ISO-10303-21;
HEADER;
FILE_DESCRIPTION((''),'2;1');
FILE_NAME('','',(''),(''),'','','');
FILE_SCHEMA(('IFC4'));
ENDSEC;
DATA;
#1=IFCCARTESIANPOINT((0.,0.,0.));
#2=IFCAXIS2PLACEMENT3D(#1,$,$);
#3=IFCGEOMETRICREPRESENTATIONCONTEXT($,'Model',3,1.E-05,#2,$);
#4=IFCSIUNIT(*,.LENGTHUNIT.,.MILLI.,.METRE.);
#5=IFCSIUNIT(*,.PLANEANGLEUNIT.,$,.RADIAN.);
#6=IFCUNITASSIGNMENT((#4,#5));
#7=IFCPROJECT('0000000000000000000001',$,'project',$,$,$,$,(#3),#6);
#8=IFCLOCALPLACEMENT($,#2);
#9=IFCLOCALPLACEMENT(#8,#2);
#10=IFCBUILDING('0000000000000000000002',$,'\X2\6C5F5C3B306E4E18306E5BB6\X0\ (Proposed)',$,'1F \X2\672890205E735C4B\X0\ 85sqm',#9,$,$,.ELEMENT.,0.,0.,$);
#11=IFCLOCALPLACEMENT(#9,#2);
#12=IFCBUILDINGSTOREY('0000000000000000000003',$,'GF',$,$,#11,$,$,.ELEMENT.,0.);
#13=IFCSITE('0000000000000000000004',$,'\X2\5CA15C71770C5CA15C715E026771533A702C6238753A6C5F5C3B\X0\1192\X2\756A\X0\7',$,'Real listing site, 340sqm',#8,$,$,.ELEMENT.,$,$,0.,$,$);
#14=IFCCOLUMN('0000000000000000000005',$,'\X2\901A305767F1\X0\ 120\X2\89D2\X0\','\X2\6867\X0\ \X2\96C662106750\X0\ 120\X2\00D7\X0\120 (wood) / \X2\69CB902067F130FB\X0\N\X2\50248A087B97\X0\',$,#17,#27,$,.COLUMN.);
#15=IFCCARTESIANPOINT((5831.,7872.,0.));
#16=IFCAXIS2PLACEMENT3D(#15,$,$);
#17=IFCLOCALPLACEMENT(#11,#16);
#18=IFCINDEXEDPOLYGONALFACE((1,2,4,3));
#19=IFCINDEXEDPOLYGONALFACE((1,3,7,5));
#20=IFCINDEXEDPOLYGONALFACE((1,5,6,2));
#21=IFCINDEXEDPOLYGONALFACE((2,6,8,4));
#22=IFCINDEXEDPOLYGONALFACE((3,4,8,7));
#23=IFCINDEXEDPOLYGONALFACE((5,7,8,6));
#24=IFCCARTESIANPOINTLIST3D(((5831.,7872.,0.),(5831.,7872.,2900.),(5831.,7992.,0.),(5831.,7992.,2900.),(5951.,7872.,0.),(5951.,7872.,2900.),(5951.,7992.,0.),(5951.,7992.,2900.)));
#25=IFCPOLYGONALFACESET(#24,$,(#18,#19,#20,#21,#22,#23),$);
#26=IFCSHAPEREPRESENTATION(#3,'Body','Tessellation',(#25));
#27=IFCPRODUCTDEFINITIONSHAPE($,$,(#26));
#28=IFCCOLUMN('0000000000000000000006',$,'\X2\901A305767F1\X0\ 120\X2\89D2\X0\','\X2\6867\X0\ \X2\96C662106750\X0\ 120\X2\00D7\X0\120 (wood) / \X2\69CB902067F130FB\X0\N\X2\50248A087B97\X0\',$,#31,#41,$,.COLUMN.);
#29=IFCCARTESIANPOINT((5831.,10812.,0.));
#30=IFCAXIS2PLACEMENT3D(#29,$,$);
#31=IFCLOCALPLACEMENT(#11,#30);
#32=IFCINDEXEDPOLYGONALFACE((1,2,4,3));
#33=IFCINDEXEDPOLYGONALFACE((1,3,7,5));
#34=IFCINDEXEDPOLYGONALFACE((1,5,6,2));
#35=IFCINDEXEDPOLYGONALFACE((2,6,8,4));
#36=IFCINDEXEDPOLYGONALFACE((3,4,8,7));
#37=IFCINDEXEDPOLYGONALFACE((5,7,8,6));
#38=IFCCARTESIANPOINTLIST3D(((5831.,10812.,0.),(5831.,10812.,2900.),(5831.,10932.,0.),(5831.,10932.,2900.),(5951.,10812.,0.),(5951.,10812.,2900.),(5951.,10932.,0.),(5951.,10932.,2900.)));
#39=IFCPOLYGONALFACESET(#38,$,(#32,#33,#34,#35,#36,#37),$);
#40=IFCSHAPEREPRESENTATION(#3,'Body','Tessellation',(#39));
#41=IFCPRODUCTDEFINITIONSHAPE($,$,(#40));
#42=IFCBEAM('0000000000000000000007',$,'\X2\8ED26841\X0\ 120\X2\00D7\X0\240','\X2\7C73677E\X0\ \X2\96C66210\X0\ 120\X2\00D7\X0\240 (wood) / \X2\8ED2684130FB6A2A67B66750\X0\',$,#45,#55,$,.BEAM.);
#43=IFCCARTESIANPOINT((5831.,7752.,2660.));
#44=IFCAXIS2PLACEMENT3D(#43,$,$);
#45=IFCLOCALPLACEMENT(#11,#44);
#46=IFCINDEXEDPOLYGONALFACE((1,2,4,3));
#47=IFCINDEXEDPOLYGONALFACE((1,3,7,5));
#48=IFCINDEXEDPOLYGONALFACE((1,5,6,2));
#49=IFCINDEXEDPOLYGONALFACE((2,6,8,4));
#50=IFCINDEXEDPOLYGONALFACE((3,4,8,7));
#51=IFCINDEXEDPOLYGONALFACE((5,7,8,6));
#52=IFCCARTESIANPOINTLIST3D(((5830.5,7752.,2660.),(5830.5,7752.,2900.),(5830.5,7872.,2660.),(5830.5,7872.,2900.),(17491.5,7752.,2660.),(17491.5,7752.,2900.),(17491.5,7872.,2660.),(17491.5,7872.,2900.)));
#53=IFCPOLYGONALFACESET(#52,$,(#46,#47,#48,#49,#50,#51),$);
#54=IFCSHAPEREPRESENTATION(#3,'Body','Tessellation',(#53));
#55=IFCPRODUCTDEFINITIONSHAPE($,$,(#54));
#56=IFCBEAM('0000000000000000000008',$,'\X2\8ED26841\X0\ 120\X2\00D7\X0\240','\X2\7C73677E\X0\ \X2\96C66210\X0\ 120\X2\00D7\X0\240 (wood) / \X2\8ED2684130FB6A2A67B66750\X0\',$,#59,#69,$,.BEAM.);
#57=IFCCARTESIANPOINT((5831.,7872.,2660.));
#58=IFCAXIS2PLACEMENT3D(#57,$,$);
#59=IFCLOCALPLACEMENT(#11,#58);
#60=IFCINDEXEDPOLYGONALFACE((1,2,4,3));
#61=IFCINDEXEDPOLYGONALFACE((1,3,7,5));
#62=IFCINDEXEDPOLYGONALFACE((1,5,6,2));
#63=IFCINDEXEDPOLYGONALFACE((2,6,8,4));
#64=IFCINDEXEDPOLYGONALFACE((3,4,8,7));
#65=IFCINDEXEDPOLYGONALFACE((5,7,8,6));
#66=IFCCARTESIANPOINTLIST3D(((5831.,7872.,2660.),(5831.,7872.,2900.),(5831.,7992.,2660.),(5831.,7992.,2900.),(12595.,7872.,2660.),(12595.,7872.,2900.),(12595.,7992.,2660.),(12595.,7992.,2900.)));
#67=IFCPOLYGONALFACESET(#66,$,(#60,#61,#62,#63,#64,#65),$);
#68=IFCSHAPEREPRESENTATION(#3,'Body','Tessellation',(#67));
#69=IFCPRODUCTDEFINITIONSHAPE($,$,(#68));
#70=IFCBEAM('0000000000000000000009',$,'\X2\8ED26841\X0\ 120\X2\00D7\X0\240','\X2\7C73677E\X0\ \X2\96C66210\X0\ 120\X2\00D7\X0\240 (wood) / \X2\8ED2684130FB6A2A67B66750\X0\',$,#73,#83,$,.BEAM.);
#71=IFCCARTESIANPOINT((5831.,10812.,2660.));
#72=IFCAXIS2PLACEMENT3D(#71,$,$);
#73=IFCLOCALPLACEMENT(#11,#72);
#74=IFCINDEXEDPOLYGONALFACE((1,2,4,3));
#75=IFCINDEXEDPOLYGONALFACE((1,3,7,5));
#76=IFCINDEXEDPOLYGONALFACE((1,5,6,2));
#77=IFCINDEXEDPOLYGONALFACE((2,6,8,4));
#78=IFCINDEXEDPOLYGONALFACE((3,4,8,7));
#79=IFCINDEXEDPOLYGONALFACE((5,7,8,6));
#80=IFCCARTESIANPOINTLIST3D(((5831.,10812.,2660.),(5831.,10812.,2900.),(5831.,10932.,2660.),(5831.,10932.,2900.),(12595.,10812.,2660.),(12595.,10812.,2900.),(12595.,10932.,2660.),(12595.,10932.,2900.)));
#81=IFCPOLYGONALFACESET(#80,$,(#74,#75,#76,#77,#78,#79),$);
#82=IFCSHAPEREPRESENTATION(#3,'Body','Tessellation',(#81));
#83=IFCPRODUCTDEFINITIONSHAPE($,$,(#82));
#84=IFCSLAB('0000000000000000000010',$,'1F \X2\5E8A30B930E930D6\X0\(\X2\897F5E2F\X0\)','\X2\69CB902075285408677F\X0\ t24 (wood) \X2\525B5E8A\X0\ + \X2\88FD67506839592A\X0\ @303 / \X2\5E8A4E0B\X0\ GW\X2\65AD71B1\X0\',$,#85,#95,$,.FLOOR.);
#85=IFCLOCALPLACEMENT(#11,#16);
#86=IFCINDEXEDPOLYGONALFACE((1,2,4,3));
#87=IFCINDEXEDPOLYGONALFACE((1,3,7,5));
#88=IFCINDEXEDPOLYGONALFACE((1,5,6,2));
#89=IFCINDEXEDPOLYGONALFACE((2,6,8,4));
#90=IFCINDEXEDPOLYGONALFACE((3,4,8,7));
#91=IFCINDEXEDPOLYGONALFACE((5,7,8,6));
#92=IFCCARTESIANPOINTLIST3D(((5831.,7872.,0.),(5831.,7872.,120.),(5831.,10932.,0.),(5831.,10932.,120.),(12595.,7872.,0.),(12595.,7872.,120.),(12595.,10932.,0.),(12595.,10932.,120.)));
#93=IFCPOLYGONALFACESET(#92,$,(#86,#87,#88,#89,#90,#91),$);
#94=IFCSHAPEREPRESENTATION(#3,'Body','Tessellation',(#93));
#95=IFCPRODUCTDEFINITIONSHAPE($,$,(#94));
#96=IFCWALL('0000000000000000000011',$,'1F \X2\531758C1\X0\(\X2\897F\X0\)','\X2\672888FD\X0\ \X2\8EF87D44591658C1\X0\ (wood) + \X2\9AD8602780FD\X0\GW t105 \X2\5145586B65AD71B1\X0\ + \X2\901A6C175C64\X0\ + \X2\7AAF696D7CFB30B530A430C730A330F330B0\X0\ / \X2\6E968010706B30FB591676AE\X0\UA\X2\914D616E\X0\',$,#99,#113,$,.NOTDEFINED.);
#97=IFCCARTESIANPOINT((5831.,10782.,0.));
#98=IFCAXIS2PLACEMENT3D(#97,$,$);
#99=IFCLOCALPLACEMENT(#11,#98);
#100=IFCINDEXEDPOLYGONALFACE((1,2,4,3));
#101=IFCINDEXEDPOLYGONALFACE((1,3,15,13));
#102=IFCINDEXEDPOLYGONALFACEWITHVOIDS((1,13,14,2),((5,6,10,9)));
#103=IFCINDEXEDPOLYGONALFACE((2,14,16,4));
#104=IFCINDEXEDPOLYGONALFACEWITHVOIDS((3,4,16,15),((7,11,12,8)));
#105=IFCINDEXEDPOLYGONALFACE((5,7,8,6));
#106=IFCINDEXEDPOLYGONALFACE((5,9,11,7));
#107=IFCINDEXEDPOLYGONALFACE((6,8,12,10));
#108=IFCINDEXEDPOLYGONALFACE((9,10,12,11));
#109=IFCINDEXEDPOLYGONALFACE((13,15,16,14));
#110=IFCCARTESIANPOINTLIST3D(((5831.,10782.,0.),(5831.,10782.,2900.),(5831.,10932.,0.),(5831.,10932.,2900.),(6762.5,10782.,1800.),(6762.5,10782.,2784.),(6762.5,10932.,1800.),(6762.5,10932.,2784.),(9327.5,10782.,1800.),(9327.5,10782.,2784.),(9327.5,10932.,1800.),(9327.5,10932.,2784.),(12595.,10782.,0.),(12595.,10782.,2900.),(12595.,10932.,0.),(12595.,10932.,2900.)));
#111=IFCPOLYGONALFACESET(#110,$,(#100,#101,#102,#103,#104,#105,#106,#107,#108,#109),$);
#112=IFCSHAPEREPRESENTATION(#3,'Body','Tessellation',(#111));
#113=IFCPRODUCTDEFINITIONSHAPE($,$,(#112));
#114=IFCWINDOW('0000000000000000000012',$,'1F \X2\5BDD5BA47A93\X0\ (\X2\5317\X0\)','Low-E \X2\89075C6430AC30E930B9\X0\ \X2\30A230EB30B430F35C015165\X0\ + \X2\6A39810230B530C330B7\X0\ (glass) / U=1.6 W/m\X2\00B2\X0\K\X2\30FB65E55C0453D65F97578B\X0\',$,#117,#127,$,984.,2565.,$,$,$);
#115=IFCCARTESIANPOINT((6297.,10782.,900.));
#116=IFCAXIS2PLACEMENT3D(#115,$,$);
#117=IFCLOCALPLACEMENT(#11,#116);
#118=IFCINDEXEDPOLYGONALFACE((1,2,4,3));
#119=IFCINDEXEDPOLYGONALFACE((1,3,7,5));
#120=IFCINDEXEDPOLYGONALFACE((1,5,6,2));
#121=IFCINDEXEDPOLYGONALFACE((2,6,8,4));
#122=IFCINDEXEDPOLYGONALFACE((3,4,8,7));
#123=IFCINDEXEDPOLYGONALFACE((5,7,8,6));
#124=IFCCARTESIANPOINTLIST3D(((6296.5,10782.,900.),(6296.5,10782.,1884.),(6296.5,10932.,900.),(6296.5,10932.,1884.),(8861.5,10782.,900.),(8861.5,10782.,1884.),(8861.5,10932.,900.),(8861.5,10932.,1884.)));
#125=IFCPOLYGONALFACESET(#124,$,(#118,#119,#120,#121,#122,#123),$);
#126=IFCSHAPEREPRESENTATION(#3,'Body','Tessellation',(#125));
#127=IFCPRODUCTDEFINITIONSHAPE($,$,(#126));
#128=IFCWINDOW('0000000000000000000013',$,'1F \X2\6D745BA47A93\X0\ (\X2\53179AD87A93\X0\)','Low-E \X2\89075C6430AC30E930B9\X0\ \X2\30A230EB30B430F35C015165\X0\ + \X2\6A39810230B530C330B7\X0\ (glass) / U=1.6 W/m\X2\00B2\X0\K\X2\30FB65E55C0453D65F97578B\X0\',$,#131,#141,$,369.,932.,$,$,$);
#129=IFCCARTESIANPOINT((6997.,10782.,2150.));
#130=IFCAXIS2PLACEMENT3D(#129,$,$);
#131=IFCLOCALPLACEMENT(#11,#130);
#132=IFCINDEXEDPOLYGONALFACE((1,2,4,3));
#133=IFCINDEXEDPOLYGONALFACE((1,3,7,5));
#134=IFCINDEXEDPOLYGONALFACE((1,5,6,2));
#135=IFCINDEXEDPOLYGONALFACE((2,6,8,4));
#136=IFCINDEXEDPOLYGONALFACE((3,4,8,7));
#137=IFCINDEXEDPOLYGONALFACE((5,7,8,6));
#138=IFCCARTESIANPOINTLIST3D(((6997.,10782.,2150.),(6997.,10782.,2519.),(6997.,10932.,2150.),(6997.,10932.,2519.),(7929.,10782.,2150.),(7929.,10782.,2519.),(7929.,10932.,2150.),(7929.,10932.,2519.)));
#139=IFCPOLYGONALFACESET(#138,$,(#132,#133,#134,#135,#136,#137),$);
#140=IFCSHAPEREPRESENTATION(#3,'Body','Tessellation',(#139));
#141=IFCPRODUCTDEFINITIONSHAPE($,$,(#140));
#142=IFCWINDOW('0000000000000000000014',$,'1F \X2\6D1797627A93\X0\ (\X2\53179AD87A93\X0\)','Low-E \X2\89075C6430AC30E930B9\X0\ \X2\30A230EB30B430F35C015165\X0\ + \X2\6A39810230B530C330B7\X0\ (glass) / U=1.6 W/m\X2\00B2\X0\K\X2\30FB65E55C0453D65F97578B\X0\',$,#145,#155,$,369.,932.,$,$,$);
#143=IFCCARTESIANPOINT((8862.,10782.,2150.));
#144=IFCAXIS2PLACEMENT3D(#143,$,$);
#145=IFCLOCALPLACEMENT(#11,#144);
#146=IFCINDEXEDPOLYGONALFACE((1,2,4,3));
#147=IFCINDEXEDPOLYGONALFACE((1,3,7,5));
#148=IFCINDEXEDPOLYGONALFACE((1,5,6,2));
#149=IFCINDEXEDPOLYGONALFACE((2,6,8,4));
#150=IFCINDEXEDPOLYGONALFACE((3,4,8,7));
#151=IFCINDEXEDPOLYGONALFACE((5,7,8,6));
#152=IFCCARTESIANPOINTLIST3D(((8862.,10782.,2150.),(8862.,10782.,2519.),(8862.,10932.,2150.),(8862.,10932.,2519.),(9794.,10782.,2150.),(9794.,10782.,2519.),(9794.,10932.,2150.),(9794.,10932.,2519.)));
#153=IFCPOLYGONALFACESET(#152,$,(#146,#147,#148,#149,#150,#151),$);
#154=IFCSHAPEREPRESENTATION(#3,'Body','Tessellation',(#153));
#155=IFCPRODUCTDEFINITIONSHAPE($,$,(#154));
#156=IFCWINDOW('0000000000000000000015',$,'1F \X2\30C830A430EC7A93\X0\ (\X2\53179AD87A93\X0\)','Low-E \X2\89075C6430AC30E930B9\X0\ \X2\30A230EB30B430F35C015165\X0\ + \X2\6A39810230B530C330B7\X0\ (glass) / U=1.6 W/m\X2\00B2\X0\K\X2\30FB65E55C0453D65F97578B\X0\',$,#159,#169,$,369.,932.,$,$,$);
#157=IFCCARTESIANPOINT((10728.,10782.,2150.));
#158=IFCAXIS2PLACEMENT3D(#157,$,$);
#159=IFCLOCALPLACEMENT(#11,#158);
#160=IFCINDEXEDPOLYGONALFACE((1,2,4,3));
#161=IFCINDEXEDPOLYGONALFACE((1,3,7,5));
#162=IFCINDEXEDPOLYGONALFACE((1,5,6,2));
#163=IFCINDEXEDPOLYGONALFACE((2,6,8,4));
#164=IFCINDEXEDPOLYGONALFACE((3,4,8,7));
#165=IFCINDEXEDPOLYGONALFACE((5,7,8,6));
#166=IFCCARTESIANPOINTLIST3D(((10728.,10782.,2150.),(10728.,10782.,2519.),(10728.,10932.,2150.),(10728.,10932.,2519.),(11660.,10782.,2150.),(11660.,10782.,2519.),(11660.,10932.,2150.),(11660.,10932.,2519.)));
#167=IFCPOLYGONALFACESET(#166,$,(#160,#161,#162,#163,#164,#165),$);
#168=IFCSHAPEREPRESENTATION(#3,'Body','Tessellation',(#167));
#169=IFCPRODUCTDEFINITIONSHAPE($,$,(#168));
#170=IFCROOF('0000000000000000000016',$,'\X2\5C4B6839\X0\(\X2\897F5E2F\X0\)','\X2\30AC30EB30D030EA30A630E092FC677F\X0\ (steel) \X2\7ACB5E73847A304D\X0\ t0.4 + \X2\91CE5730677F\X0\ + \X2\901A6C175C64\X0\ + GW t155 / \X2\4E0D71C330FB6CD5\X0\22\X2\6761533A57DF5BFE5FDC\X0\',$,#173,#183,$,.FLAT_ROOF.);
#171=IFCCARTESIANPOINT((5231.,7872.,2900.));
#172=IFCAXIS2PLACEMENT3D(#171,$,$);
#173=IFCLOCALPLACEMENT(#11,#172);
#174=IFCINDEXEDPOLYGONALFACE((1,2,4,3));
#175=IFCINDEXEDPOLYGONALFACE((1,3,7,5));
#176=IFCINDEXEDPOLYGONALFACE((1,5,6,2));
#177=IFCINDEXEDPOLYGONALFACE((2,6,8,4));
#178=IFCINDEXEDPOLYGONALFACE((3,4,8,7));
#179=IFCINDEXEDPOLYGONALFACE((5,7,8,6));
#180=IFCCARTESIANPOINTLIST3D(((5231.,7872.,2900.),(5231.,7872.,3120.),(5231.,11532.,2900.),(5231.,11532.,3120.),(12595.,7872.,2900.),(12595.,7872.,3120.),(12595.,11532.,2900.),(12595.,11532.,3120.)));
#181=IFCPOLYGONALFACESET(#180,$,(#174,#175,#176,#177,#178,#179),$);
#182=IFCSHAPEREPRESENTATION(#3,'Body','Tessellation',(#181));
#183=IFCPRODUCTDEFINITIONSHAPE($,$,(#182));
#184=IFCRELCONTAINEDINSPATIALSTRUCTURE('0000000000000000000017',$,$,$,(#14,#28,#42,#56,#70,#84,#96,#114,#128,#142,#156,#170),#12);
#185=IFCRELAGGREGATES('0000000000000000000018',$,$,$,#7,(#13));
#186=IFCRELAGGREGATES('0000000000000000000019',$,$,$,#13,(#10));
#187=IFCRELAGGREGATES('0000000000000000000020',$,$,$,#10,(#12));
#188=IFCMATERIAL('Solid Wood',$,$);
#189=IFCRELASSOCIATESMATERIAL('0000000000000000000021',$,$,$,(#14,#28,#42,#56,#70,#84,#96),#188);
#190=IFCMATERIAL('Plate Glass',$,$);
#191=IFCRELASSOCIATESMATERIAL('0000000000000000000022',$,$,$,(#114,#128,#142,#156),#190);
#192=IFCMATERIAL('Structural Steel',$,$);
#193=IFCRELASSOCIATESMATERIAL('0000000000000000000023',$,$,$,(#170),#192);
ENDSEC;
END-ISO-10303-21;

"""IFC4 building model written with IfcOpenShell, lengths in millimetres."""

from ifc_helpers import new_model, si_unit, frame, frame_2d, origin, place, context, project, spatial, rectangle, extrude, material, element, fill, save


model = new_model("IFC4")

# Units and contexts
model_context = context("Model", 3, precision=1e-05, world=origin())
ifc_project = project(units=[si_unit("LENGTHUNIT", "METRE", prefix="MILLI"), si_unit("PLANEANGLEUNIT", "RADIAN")], contexts=[model_context])

# Site, building, storey
site_placement = place(None, origin())
site = spatial("IfcSite", under=ifc_project, at=site_placement, Name="岡山県岡山市東区瀬戸町江尻1192番7", ObjectType="Real listing site, 340sqm", CompositionType="ELEMENT", RefElevation=0.0)
building_placement = place(site_placement, origin())
building = spatial("IfcBuilding", under=site, at=building_placement, Name="江尻の丘の家 (Proposed)", ObjectType="1F 木造平屋 85sqm", CompositionType="ELEMENT", ElevationOfRefHeight=0.0, ElevationOfTerrain=0.0)
storey_placement = place(building_placement, origin())
storey = spatial("IfcBuildingStorey", under=building, at=storey_placement, Name="GF", CompositionType="ELEMENT", Elevation=0.0)

# Columns
ifc_material_1 = material(Name="Solid Wood")
column_1_placement = place(storey_placement, frame((5831.0, 7872.0, 0.0)))
element("IfcColumn", 1, at=column_1_placement, inside=storey, material=ifc_material_1, Name="通し柱 120角", Description="桧 集成材 120×120 (wood) / 構造柱・N値計算", PredefinedType="COLUMN", context=model_context, shape_type="SweptSolid", body=[
    extrude(rectangle(XDim=120.0, YDim=120.0, at=frame_2d((60.0, 60.0))), frame((5831.0, 7872.0, 0.0)), (0.0, 0.0, 1.0), 2900.0),
])
column_2_placement = place(storey_placement, frame((5831.0, 10812.0, 0.0)))
element("IfcColumn", 2, at=column_2_placement, inside=storey, material=ifc_material_1, Name="通し柱 120角", Description="桧 集成材 120×120 (wood) / 構造柱・N値計算", PredefinedType="COLUMN", context=model_context, shape_type="SweptSolid", body=[
    extrude(rectangle(XDim=120.0, YDim=120.0, at=frame_2d((60.0, 60.0))), frame((5831.0, 10812.0, 0.0)), (0.0, 0.0, 1.0), 2900.0),
])

# Beams
beam_1_placement = place(storey_placement, frame((5831.0, 7752.0, 2660.0)))
element("IfcBeam", 3, at=beam_1_placement, inside=storey, material=ifc_material_1, Name="軒桁 120×240", Description="米松 集成 120×240 (wood) / 軒桁・横架材", PredefinedType="BEAM", context=model_context, shape_type="SweptSolid", body=[
    extrude(rectangle(XDim=11661.0, YDim=120.0, at=frame_2d((5830.0, 60.0))), frame((5831.0, 7752.0, 2660.0)), (0.0, 0.0, 1.0), 240.0),
])
beam_2_placement = place(storey_placement, frame((5831.0, 7872.0, 2660.0)))
element("IfcBeam", 4, at=beam_2_placement, inside=storey, material=ifc_material_1, Name="軒桁 120×240", Description="米松 集成 120×240 (wood) / 軒桁・横架材", PredefinedType="BEAM", context=model_context, shape_type="SweptSolid", body=[
    extrude(rectangle(XDim=6764.0, YDim=120.0, at=frame_2d((3382.0, 60.0))), frame((5831.0, 7872.0, 2660.0)), (0.0, 0.0, 1.0), 240.0),
])
beam_3_placement = place(storey_placement, frame((5831.0, 10812.0, 2660.0)))
element("IfcBeam", 5, at=beam_3_placement, inside=storey, material=ifc_material_1, Name="軒桁 120×240", Description="米松 集成 120×240 (wood) / 軒桁・横架材", PredefinedType="BEAM", context=model_context, shape_type="SweptSolid", body=[
    extrude(rectangle(XDim=6764.0, YDim=120.0, at=frame_2d((3382.0, 60.0))), frame((5831.0, 10812.0, 2660.0)), (0.0, 0.0, 1.0), 240.0),
])

# Slab
slab_placement = place(storey_placement, frame((5831.0, 7872.0, 0.0)))
element("IfcSlab", 6, at=slab_placement, inside=storey, material=ifc_material_1, Name="1F 床スラブ(西帯)", Description="構造用合板 t24 (wood) 剛床 + 製材根太 @303 / 床下 GW断熱", PredefinedType="FLOOR", context=model_context, shape_type="SweptSolid", body=[
    extrude(rectangle(XDim=6764.0, YDim=3060.0, at=frame_2d((3382.0, 1530.0))), frame((5831.0, 7872.0, 0.0)), (0.0, 0.0, 1.0), 120.0),
])

# Wall, openings, windows
wall_1_placement = place(storey_placement, frame((5831.0, 10782.0, 0.0)))
wall_1 = element("IfcWall", 7, at=wall_1_placement, inside=storey, material=ifc_material_1, Name="1F 北壁(西)", Description="木製 軸組外壁 (wood) + 高性能GW t105 充填断熱 + 通気層 + 窯業系サイディング / 準耐火・外皮UA配慮", PredefinedType="NOTDEFINED", context=model_context, shape_type="SweptSolid", body=[
    extrude(rectangle(XDim=6764.0, YDim=150.0, at=frame_2d((3382.0, 75.0))), frame((5831.0, 10782.0, 0.0)), (0.0, 0.0, 1.0), 2900.0),
])
opening_1_placement = place(storey_placement, frame((6297.0, 10782.0, 900.0)))
opening_1 = element("IfcOpeningElement", 8, at=opening_1_placement, cuts=wall_1, PredefinedType="NOTDEFINED", context=model_context, shape_type="SweptSolid", body=[
    extrude(rectangle(XDim=2565.0, YDim=150.0, at=frame_2d((1282.0, 75.0))), frame((6297.0, 10782.0, 900.0)), (0.0, 0.0, 1.0), 984.0),
])
opening_2_placement = place(storey_placement, frame((6997.0, 10782.0, 2150.0)))
opening_2 = element("IfcOpeningElement", 9, at=opening_2_placement, cuts=wall_1, PredefinedType="NOTDEFINED", context=model_context, shape_type="SweptSolid", body=[
    extrude(rectangle(XDim=932.0, YDim=150.0, at=frame_2d((466.0, 75.0))), frame((6997.0, 10782.0, 2150.0)), (0.0, 0.0, 1.0), 369.0),
])
opening_3_placement = place(storey_placement, frame((8862.0, 10782.0, 2150.0)))
opening_3 = element("IfcOpeningElement", 10, at=opening_3_placement, cuts=wall_1, PredefinedType="NOTDEFINED", context=model_context, shape_type="SweptSolid", body=[
    extrude(rectangle(XDim=932.0, YDim=150.0, at=frame_2d((466.0, 75.0))), frame((8862.0, 10782.0, 2150.0)), (0.0, 0.0, 1.0), 369.0),
])
opening_4_placement = place(storey_placement, frame((10728.0, 10782.0, 2150.0)))
opening_4 = element("IfcOpeningElement", 11, at=opening_4_placement, cuts=wall_1, PredefinedType="NOTDEFINED", context=model_context, shape_type="SweptSolid", body=[
    extrude(rectangle(XDim=932.0, YDim=150.0, at=frame_2d((466.0, 75.0))), frame((10728.0, 10782.0, 2150.0)), (0.0, 0.0, 1.0), 369.0),
])
ifc_material_2 = material(Name="Plate Glass")
window_1_placement = place(storey_placement, frame((6297.0, 10782.0, 900.0)))
window_1 = element("IfcWindow", 12, at=window_1_placement, inside=storey, material=ifc_material_2, Name="1F 寝室窓 (北)", Description="Low-E 複層ガラス アルゴン封入 + 樹脂サッシ (glass) / U=1.6 W/m²K・日射取得型", OverallHeight=984.0, OverallWidth=2565.0, context=model_context, shape_type="SweptSolid", body=[
    extrude(rectangle(XDim=2565.0, YDim=150.0, at=frame_2d((1282.0, 75.0))), frame((6297.0, 10782.0, 900.0)), (0.0, 0.0, 1.0), 984.0),
])
fill(opening_1, window_1)
window_2_placement = place(storey_placement, frame((6997.0, 10782.0, 2150.0)))
window_2 = element("IfcWindow", 13, at=window_2_placement, inside=storey, material=ifc_material_2, Name="1F 浴室窓 (北高窓)", Description="Low-E 複層ガラス アルゴン封入 + 樹脂サッシ (glass) / U=1.6 W/m²K・日射取得型", OverallHeight=369.0, OverallWidth=932.0, context=model_context, shape_type="SweptSolid", body=[
    extrude(rectangle(XDim=932.0, YDim=150.0, at=frame_2d((466.0, 75.0))), frame((6997.0, 10782.0, 2150.0)), (0.0, 0.0, 1.0), 369.0),
])
fill(opening_2, window_2)
window_3_placement = place(storey_placement, frame((8862.0, 10782.0, 2150.0)))
window_3 = element("IfcWindow", 14, at=window_3_placement, inside=storey, material=ifc_material_2, Name="1F 洗面窓 (北高窓)", Description="Low-E 複層ガラス アルゴン封入 + 樹脂サッシ (glass) / U=1.6 W/m²K・日射取得型", OverallHeight=369.0, OverallWidth=932.0, context=model_context, shape_type="SweptSolid", body=[
    extrude(rectangle(XDim=932.0, YDim=150.0, at=frame_2d((466.0, 75.0))), frame((8862.0, 10782.0, 2150.0)), (0.0, 0.0, 1.0), 369.0),
])
fill(opening_3, window_3)
window_4_placement = place(storey_placement, frame((10728.0, 10782.0, 2150.0)))
window_4 = element("IfcWindow", 15, at=window_4_placement, inside=storey, material=ifc_material_2, Name="1F トイレ窓 (北高窓)", Description="Low-E 複層ガラス アルゴン封入 + 樹脂サッシ (glass) / U=1.6 W/m²K・日射取得型", OverallHeight=369.0, OverallWidth=932.0, context=model_context, shape_type="SweptSolid", body=[
    extrude(rectangle(XDim=932.0, YDim=150.0, at=frame_2d((466.0, 75.0))), frame((10728.0, 10782.0, 2150.0)), (0.0, 0.0, 1.0), 369.0),
])
fill(opening_4, window_4)

# Roof
ifc_material_3 = material(Name="Structural Steel")
roof_placement = place(storey_placement, frame((5231.0, 7872.0, 2900.0)))
element("IfcRoof", 16, at=roof_placement, inside=storey, material=ifc_material_3, Name="屋根(西帯)", Description="ガルバリウム鋼板 (steel) 立平葺き t0.4 + 野地板 + 通気層 + GW t155 / 不燃・法22条区域対応", PredefinedType="FLAT_ROOF", context=model_context, shape_type="SweptSolid", body=[
    extrude(rectangle(XDim=7364.0, YDim=3660.0, at=frame_2d((3682.0, 1830.0))), frame((5231.0, 7872.0, 2900.0)), (0.0, 0.0, 1.0), 220.0),
])

save(model, "model.ifc")
